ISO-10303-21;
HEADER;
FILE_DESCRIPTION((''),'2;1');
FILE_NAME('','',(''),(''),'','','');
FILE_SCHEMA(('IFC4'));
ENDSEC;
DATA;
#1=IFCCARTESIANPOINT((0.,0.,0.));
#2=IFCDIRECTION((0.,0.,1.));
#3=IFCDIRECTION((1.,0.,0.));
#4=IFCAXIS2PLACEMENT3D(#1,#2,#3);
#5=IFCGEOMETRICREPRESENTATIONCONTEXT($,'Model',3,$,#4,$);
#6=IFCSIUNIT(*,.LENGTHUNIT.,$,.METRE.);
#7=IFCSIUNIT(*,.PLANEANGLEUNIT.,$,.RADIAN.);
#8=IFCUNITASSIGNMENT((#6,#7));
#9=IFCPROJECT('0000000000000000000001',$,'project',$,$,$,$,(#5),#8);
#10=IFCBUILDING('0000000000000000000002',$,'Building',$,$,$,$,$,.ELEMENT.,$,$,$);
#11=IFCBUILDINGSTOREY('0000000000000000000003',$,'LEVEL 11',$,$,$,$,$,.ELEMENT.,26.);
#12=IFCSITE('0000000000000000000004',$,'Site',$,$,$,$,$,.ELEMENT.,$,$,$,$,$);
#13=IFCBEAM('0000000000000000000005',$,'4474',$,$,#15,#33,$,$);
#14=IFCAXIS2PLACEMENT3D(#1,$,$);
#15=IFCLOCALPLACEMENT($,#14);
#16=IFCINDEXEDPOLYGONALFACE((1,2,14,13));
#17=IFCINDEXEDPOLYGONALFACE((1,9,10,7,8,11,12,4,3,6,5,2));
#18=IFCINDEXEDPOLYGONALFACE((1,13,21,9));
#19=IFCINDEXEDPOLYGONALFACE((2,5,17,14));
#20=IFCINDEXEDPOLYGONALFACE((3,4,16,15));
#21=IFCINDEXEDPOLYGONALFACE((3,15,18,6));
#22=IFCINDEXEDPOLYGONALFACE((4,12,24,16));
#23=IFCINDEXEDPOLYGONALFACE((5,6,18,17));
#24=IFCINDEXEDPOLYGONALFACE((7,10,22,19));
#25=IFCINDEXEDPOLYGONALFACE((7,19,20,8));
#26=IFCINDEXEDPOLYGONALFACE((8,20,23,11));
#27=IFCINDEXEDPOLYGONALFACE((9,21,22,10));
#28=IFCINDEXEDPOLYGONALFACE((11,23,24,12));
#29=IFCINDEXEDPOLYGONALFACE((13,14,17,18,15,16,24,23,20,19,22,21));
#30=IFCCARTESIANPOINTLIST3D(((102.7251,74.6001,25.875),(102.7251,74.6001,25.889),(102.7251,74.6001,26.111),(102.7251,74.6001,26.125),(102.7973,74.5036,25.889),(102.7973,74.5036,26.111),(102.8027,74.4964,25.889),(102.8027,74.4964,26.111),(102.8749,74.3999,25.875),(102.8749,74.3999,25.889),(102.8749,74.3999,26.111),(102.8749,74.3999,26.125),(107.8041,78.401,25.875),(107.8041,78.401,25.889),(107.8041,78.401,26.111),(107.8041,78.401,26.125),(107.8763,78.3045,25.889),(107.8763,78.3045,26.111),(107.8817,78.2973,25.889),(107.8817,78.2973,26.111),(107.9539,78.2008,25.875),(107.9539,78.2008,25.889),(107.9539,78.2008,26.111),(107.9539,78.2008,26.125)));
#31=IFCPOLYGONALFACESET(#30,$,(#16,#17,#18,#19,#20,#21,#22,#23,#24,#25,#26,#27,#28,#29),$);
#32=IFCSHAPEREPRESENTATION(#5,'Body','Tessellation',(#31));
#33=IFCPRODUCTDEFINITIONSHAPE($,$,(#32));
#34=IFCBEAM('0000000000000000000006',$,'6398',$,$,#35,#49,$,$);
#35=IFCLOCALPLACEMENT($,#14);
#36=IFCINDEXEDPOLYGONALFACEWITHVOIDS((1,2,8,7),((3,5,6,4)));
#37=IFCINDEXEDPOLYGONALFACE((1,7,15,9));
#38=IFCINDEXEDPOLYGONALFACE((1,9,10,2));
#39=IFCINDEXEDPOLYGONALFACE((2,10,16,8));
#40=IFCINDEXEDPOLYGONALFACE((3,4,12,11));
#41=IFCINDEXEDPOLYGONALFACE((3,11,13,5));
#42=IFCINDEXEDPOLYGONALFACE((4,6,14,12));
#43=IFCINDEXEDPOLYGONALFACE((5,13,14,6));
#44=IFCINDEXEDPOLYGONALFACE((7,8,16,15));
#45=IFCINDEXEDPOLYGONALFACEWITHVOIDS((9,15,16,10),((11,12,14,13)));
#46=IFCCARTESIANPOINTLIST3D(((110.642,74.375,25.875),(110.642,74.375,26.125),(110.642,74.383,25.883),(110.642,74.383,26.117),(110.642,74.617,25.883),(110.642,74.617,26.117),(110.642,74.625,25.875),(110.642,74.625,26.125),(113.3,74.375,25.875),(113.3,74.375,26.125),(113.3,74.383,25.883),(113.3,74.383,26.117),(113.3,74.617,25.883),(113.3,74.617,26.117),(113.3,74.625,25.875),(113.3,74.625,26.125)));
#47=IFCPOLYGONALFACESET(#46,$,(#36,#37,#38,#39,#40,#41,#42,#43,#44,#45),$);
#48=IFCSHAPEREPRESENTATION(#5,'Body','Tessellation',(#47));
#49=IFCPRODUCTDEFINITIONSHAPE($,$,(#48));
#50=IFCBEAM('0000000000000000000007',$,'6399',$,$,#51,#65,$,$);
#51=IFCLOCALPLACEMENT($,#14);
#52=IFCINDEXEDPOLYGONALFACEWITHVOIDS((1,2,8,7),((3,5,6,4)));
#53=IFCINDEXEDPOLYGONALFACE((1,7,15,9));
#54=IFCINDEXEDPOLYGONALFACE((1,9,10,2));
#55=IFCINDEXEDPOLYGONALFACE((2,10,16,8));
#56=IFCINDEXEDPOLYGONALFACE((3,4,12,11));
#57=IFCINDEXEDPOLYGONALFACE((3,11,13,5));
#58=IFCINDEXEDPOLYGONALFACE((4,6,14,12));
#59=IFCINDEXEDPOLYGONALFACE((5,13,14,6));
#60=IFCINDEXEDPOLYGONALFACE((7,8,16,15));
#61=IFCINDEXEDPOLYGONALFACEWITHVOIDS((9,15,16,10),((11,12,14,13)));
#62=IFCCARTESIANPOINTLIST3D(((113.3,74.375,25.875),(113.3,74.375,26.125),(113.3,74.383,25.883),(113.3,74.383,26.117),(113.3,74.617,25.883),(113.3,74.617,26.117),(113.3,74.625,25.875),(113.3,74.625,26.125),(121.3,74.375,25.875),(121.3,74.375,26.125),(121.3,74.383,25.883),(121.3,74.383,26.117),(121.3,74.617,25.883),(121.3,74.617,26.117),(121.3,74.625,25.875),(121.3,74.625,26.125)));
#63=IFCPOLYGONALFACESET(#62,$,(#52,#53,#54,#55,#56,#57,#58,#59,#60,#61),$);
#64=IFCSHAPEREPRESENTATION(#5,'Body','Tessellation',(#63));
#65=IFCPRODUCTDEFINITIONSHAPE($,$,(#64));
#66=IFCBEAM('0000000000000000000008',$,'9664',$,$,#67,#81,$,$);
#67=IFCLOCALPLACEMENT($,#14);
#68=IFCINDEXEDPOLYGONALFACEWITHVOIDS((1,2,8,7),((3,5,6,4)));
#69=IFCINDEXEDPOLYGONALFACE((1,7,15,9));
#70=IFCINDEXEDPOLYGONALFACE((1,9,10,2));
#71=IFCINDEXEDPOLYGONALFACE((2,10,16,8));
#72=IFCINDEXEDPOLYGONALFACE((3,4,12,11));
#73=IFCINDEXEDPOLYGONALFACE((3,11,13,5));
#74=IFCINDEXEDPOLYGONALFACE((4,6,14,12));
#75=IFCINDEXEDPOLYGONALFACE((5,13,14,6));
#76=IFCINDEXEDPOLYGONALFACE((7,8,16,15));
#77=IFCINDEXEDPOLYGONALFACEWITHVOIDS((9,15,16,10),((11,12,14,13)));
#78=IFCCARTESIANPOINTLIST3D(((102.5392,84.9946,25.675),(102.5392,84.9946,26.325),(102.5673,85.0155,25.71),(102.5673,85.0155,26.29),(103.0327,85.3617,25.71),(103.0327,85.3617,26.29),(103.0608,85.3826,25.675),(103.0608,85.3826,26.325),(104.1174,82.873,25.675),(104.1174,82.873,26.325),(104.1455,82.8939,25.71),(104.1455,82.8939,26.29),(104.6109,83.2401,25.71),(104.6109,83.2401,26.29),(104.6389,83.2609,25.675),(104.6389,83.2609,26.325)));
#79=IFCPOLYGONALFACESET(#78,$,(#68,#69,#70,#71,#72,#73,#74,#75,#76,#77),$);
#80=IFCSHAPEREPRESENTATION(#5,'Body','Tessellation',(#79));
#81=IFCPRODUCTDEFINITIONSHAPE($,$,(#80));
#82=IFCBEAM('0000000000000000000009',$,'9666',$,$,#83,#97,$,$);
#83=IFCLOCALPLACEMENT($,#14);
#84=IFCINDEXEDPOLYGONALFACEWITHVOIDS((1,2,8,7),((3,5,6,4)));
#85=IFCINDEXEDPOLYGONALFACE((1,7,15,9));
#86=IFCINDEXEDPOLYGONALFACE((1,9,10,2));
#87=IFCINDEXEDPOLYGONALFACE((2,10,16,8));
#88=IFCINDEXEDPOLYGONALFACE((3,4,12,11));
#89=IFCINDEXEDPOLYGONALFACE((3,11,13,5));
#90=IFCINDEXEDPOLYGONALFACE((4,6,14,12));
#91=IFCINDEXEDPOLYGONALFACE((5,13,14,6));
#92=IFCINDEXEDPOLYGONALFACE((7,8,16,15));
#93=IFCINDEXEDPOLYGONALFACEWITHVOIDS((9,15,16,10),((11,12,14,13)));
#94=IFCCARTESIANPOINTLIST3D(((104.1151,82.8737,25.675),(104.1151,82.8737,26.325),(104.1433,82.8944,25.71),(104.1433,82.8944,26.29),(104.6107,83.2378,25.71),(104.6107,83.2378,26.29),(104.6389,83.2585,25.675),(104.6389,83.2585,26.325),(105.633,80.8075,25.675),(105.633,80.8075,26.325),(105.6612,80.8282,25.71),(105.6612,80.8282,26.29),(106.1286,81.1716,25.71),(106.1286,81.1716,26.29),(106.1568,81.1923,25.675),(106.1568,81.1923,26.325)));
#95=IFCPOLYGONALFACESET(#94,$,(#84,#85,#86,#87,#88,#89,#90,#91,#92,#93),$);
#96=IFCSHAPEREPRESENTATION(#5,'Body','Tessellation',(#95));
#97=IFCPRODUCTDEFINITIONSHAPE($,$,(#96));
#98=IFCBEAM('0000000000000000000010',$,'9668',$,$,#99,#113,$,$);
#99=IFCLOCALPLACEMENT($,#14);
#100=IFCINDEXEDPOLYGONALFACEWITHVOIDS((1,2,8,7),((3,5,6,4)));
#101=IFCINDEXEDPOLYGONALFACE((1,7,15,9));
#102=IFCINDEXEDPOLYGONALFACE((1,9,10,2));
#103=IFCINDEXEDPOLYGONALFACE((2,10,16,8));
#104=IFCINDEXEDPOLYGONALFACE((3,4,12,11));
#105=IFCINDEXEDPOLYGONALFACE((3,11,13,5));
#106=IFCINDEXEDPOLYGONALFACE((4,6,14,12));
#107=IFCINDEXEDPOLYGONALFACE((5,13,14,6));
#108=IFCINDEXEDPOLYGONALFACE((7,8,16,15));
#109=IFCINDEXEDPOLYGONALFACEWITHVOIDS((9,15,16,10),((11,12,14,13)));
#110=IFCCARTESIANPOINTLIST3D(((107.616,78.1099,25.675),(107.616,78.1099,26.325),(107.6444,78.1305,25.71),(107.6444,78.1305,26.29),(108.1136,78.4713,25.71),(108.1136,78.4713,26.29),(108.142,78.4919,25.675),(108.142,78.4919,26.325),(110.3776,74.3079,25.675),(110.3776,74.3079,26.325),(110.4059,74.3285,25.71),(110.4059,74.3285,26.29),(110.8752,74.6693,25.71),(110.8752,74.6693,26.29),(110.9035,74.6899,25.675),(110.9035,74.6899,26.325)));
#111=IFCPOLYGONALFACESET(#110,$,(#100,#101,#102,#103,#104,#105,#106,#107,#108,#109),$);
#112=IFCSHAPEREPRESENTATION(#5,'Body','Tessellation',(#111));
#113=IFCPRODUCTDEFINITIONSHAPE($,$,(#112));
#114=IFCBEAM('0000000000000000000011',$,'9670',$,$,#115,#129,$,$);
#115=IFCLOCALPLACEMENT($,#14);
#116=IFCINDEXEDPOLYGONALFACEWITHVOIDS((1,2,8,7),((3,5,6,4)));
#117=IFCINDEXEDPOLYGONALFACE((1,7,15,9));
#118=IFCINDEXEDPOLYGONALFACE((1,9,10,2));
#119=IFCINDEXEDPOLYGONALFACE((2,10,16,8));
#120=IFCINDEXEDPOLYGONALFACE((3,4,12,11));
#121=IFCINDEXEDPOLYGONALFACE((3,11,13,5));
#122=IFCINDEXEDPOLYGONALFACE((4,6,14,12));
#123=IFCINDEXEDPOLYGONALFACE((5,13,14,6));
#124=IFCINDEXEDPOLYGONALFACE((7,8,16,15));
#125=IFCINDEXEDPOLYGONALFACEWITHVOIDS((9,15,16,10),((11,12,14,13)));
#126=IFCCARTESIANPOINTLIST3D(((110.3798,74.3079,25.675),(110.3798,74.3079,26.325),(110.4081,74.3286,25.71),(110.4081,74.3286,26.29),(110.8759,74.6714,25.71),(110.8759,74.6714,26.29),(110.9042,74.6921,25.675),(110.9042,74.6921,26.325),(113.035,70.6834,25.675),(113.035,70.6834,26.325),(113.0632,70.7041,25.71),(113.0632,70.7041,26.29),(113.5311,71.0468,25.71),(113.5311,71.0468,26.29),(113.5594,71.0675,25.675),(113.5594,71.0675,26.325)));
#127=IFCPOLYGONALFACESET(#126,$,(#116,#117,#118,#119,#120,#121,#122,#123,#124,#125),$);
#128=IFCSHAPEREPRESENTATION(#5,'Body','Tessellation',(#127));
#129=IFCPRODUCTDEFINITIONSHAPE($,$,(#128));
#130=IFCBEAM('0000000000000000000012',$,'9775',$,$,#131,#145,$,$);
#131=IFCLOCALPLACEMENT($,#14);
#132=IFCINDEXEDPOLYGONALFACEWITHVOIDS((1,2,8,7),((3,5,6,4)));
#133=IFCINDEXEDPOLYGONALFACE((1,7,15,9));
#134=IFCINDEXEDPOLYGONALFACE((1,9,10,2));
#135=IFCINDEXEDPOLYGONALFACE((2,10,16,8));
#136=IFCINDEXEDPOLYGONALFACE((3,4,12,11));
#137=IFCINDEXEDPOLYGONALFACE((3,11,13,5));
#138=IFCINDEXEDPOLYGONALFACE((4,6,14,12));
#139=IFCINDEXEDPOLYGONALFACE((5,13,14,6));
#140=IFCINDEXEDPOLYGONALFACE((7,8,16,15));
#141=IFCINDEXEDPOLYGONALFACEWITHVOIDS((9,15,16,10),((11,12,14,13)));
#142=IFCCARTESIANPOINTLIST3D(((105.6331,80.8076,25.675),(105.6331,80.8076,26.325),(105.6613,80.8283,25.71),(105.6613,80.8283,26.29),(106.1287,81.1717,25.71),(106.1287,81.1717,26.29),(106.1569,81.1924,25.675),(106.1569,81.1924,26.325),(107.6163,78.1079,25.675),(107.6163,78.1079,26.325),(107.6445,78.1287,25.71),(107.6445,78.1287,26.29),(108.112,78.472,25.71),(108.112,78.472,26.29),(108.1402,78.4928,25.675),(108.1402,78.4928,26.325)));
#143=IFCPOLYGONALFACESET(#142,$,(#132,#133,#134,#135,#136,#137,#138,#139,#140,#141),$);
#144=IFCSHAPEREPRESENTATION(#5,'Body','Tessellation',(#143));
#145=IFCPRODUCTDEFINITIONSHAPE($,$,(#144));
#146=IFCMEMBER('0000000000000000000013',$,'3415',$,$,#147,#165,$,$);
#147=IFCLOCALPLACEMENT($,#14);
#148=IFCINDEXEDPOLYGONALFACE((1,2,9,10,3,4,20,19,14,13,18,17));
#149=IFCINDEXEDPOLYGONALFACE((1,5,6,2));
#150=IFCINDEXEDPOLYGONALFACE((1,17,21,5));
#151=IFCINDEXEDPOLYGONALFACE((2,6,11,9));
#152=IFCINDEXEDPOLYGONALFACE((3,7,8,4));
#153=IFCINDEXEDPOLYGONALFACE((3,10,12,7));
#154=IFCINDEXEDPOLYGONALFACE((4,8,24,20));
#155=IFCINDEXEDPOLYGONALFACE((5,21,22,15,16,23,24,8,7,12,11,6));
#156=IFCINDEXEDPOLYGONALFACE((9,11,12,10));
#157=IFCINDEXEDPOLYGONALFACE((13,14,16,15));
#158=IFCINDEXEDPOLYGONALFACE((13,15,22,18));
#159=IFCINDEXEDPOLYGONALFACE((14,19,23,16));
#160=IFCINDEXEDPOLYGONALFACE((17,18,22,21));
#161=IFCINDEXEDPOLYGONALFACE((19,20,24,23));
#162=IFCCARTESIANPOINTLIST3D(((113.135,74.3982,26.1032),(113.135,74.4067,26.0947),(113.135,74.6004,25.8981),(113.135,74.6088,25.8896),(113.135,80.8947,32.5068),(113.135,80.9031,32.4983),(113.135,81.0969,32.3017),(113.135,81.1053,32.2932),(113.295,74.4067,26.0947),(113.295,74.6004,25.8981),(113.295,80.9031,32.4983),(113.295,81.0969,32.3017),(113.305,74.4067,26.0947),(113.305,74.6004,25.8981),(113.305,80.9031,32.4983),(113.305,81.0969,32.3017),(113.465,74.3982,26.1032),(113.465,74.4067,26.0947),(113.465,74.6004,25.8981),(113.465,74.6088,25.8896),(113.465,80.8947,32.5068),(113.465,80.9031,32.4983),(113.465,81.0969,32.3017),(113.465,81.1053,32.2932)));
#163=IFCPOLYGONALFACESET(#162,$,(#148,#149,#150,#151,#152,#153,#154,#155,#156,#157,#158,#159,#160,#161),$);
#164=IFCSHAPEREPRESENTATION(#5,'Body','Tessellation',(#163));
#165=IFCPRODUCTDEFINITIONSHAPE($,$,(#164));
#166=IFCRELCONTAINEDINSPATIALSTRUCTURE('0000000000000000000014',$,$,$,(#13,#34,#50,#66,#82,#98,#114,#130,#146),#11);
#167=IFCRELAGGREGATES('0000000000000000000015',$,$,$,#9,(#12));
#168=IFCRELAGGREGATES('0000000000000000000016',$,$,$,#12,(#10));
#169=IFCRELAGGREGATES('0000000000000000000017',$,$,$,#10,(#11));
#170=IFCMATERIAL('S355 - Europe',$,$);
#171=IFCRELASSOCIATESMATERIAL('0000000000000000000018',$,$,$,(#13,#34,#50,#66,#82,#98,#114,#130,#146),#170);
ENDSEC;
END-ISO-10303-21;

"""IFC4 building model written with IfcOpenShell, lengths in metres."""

from ifc_helpers import new_model, si_unit, frame, origin_with_axes, origin_2d_with_axis, place, context, project, spatial, hollow_rectangle, i_section, extrude, material, material_profile, profile_set, profile_usage, element, save


model = new_model("IFC4")

# Units and contexts
model_context = context("Model", 3, world=origin_with_axes())
ifc_project = project(units=[si_unit("LENGTHUNIT", "METRE"), si_unit("PLANEANGLEUNIT", "RADIAN")], contexts=[model_context])

# Site, building, storey
site = spatial("IfcSite", under=ifc_project, Name="Site", CompositionType="ELEMENT")
building = spatial("IfcBuilding", under=site, Name="Building", CompositionType="ELEMENT")
storey = spatial("IfcBuildingStorey", under=building, Name="LEVEL 11", CompositionType="ELEMENT", Elevation=26.0)

# Shared definitions
ifc_material = material(Name="S355 - Europe")

# Beams
ifc_material_profile_1 = material_profile(ifc_material, i_section(OverallWidth=0.25, OverallDepth=0.25, WebThickness=0.009, FlangeThickness=0.014, at=origin_2d_with_axis()))
ifc_profile_set_1 = profile_set([ifc_material_profile_1])
ifc_profile_usage_1 = profile_usage(ifc_profile_set_1, cardinal=10)
beam_1_placement = place(None, frame((107.879, 78.3009, 26.0), z_axis=(-0.800631, -0.599157, 0.0), x_axis=(0.599157, -0.800631, 0.0)))
element("IfcBeam", 1, at=beam_1_placement, inside=storey, material=ifc_profile_usage_1, Name="4474", context=model_context, shape_type="SweptSolid", body=[
    extrude(i_section(OverallWidth=0.25, OverallDepth=0.25, WebThickness=0.009, FlangeThickness=0.014, at=origin_2d_with_axis()), origin_with_axes(), (0.0, 0.0, 1.0), 6.3437),
])
ifc_material_profile_2 = material_profile(ifc_material, hollow_rectangle(XDim=0.25, YDim=0.25, WallThickness=0.008, at=origin_2d_with_axis()))
ifc_profile_set_2 = profile_set([ifc_material_profile_2])
ifc_profile_usage_2 = profile_usage(ifc_profile_set_2, cardinal=10)
beam_2_placement = place(None, frame((110.642, 74.5, 26.0), z_axis=(1.0, 0.0, 0.0), x_axis=(0.0, 1.0, 0.0)))
element("IfcBeam", 2, at=beam_2_placement, inside=storey, material=ifc_profile_usage_2, Name="6398", context=model_context, shape_type="SweptSolid", body=[
    extrude(hollow_rectangle(XDim=0.25, YDim=0.25, WallThickness=0.008, at=origin_2d_with_axis()), origin_with_axes(), (0.0, 0.0, 1.0), 2.658),
])
ifc_material_profile_3 = material_profile(ifc_material, hollow_rectangle(XDim=0.25, YDim=0.25, WallThickness=0.008, at=origin_2d_with_axis()))
ifc_profile_set_3 = profile_set([ifc_material_profile_3])
ifc_profile_usage_3 = profile_usage(ifc_profile_set_3, cardinal=10)
beam_3_placement = place(None, frame((113.3, 74.5, 26.0), z_axis=(1.0, 0.0, 0.0), x_axis=(0.0, 1.0, 0.0)))
element("IfcBeam", 3, at=beam_3_placement, inside=storey, material=ifc_profile_usage_3, Name="6399", context=model_context, shape_type="SweptSolid", body=[
    extrude(hollow_rectangle(XDim=0.25, YDim=0.25, WallThickness=0.008, at=origin_2d_with_axis()), origin_with_axes(), (0.0, 0.0, 1.0), 8.0),
])
ifc_material_profile_4 = material_profile(ifc_material, hollow_rectangle(XDim=0.65, YDim=0.65, WallThickness=0.035, at=origin_2d_with_axis()))
ifc_profile_set_4 = profile_set([ifc_material_profile_4])
ifc_profile_usage_4 = profile_usage(ifc_profile_set_4, cardinal=10)
beam_4_placement = place(None, frame((102.8, 85.1886, 26.0), z_axis=(0.596835, -0.802364, 0.0), x_axis=(0.802692, 0.596394, 0.0)))
element("IfcBeam", 4, at=beam_4_placement, inside=storey, material=ifc_profile_usage_4, Name="9664", context=model_context, shape_type="SweptSolid", body=[
    extrude(hollow_rectangle(XDim=0.65, YDim=0.65, WallThickness=0.035, at=origin_2d_with_axis()), origin_with_axes(), (0.0, 0.0, 1.0), 2.6442),
])
ifc_material_profile_5 = material_profile(ifc_material, hollow_rectangle(XDim=0.65, YDim=0.65, WallThickness=0.035, at=origin_2d_with_axis()))
ifc_profile_set_5 = profile_set([ifc_material_profile_5])
ifc_profile_usage_5 = profile_usage(ifc_profile_set_5, cardinal=10)
beam_5_placement = place(None, frame((104.377, 83.0661, 26.0), z_axis=(0.592045, -0.805905, 0.0), x_axis=(0.805798, 0.59219, 0.0)))
element("IfcBeam", 5, at=beam_5_placement, inside=storey, material=ifc_profile_usage_5, Name="9666", context=model_context, shape_type="SweptSolid", body=[
    extrude(hollow_rectangle(XDim=0.65, YDim=0.65, WallThickness=0.035, at=origin_2d_with_axis()), origin_with_axes(), (0.0, 0.0, 1.0), 2.5638),
])
ifc_material_profile_6 = material_profile(ifc_material, hollow_rectangle(XDim=0.65, YDim=0.65, WallThickness=0.035, at=origin_2d_with_axis()))
ifc_profile_set_6 = profile_set([ifc_material_profile_6])
ifc_profile_usage_6 = profile_usage(ifc_profile_set_6, cardinal=10)
beam_6_placement = place(None, frame((107.879, 78.3009, 26.0), z_axis=(0.587676, -0.809096, 0.0), x_axis=(0.808867, 0.587992, 0.0)))
element("IfcBeam", 6, at=beam_6_placement, inside=storey, material=ifc_profile_usage_6, Name="9668", context=model_context, shape_type="SweptSolid", body=[
    extrude(hollow_rectangle(XDim=0.65, YDim=0.65, WallThickness=0.035, at=origin_2d_with_axis()), origin_with_axes(), (0.0, 0.0, 1.0), 4.699),
])
ifc_material_profile_7 = material_profile(ifc_material, hollow_rectangle(XDim=0.65, YDim=0.65, WallThickness=0.035, at=origin_2d_with_axis()))
ifc_profile_set_7 = profile_set([ifc_material_profile_7])
ifc_profile_usage_7 = profile_usage(ifc_profile_set_7, cardinal=10)
beam_7_placement = place(None, frame((110.642, 74.5, 26.0), z_axis=(0.590953, -0.806706, 0.0), x_axis=(0.806353, 0.591435, 0.0)))
element("IfcBeam", 7, at=beam_7_placement, inside=storey, material=ifc_profile_usage_7, Name="9670", context=model_context, shape_type="SweptSolid", body=[
    extrude(hollow_rectangle(XDim=0.65, YDim=0.65, WallThickness=0.035, at=origin_2d_with_axis()), origin_with_axes(), (0.0, 0.0, 1.0), 4.493),
])
ifc_material_profile_8 = material_profile(ifc_material, hollow_rectangle(XDim=0.65, YDim=0.65, WallThickness=0.035, at=origin_2d_with_axis()))
ifc_profile_set_8 = profile_set([ifc_material_profile_8])
ifc_profile_usage_8 = profile_usage(ifc_profile_set_8, cardinal=10)
beam_8_placement = place(None, frame((105.895, 81.0, 26.0), z_axis=(0.592045, -0.805905, 0.0), x_axis=(0.805056, 0.593199, 0.0)))
element("IfcBeam", 8, at=beam_8_placement, inside=storey, material=ifc_profile_usage_8, Name="9775", context=model_context, shape_type="SweptSolid", body=[
    extrude(hollow_rectangle(XDim=0.65, YDim=0.65, WallThickness=0.035, at=origin_2d_with_axis()), origin_with_axes(), (0.0, 0.0, 1.0), 3.3498),
])

# Member
ifc_material_profile_9 = material_profile(ifc_material, i_section(OverallWidth=0.33, OverallDepth=0.3, WebThickness=0.01, FlangeThickness=0.012, at=origin_2d_with_axis()))
ifc_profile_set_9 = profile_set([ifc_material_profile_9])
ifc_profile_usage_9 = profile_usage(ifc_profile_set_9, cardinal=10)
member_1_placement = place(None, frame((113.3, 81.0, 32.4), z_axis=(0.0, -0.712178, -0.701999), x_axis=(1.0, 0.0, 0.0)))
element("IfcMember", 9, at=member_1_placement, inside=storey, material=ifc_profile_usage_9, Name="3415", context=model_context, shape_type="SweptSolid", body=[
    extrude(i_section(OverallWidth=0.33, OverallDepth=0.3, WebThickness=0.01, FlangeThickness=0.012, at=origin_2d_with_axis()), origin_with_axes(), (0.0, 0.0, 1.0), 9.122),
])

save(model, "model.ifc")
